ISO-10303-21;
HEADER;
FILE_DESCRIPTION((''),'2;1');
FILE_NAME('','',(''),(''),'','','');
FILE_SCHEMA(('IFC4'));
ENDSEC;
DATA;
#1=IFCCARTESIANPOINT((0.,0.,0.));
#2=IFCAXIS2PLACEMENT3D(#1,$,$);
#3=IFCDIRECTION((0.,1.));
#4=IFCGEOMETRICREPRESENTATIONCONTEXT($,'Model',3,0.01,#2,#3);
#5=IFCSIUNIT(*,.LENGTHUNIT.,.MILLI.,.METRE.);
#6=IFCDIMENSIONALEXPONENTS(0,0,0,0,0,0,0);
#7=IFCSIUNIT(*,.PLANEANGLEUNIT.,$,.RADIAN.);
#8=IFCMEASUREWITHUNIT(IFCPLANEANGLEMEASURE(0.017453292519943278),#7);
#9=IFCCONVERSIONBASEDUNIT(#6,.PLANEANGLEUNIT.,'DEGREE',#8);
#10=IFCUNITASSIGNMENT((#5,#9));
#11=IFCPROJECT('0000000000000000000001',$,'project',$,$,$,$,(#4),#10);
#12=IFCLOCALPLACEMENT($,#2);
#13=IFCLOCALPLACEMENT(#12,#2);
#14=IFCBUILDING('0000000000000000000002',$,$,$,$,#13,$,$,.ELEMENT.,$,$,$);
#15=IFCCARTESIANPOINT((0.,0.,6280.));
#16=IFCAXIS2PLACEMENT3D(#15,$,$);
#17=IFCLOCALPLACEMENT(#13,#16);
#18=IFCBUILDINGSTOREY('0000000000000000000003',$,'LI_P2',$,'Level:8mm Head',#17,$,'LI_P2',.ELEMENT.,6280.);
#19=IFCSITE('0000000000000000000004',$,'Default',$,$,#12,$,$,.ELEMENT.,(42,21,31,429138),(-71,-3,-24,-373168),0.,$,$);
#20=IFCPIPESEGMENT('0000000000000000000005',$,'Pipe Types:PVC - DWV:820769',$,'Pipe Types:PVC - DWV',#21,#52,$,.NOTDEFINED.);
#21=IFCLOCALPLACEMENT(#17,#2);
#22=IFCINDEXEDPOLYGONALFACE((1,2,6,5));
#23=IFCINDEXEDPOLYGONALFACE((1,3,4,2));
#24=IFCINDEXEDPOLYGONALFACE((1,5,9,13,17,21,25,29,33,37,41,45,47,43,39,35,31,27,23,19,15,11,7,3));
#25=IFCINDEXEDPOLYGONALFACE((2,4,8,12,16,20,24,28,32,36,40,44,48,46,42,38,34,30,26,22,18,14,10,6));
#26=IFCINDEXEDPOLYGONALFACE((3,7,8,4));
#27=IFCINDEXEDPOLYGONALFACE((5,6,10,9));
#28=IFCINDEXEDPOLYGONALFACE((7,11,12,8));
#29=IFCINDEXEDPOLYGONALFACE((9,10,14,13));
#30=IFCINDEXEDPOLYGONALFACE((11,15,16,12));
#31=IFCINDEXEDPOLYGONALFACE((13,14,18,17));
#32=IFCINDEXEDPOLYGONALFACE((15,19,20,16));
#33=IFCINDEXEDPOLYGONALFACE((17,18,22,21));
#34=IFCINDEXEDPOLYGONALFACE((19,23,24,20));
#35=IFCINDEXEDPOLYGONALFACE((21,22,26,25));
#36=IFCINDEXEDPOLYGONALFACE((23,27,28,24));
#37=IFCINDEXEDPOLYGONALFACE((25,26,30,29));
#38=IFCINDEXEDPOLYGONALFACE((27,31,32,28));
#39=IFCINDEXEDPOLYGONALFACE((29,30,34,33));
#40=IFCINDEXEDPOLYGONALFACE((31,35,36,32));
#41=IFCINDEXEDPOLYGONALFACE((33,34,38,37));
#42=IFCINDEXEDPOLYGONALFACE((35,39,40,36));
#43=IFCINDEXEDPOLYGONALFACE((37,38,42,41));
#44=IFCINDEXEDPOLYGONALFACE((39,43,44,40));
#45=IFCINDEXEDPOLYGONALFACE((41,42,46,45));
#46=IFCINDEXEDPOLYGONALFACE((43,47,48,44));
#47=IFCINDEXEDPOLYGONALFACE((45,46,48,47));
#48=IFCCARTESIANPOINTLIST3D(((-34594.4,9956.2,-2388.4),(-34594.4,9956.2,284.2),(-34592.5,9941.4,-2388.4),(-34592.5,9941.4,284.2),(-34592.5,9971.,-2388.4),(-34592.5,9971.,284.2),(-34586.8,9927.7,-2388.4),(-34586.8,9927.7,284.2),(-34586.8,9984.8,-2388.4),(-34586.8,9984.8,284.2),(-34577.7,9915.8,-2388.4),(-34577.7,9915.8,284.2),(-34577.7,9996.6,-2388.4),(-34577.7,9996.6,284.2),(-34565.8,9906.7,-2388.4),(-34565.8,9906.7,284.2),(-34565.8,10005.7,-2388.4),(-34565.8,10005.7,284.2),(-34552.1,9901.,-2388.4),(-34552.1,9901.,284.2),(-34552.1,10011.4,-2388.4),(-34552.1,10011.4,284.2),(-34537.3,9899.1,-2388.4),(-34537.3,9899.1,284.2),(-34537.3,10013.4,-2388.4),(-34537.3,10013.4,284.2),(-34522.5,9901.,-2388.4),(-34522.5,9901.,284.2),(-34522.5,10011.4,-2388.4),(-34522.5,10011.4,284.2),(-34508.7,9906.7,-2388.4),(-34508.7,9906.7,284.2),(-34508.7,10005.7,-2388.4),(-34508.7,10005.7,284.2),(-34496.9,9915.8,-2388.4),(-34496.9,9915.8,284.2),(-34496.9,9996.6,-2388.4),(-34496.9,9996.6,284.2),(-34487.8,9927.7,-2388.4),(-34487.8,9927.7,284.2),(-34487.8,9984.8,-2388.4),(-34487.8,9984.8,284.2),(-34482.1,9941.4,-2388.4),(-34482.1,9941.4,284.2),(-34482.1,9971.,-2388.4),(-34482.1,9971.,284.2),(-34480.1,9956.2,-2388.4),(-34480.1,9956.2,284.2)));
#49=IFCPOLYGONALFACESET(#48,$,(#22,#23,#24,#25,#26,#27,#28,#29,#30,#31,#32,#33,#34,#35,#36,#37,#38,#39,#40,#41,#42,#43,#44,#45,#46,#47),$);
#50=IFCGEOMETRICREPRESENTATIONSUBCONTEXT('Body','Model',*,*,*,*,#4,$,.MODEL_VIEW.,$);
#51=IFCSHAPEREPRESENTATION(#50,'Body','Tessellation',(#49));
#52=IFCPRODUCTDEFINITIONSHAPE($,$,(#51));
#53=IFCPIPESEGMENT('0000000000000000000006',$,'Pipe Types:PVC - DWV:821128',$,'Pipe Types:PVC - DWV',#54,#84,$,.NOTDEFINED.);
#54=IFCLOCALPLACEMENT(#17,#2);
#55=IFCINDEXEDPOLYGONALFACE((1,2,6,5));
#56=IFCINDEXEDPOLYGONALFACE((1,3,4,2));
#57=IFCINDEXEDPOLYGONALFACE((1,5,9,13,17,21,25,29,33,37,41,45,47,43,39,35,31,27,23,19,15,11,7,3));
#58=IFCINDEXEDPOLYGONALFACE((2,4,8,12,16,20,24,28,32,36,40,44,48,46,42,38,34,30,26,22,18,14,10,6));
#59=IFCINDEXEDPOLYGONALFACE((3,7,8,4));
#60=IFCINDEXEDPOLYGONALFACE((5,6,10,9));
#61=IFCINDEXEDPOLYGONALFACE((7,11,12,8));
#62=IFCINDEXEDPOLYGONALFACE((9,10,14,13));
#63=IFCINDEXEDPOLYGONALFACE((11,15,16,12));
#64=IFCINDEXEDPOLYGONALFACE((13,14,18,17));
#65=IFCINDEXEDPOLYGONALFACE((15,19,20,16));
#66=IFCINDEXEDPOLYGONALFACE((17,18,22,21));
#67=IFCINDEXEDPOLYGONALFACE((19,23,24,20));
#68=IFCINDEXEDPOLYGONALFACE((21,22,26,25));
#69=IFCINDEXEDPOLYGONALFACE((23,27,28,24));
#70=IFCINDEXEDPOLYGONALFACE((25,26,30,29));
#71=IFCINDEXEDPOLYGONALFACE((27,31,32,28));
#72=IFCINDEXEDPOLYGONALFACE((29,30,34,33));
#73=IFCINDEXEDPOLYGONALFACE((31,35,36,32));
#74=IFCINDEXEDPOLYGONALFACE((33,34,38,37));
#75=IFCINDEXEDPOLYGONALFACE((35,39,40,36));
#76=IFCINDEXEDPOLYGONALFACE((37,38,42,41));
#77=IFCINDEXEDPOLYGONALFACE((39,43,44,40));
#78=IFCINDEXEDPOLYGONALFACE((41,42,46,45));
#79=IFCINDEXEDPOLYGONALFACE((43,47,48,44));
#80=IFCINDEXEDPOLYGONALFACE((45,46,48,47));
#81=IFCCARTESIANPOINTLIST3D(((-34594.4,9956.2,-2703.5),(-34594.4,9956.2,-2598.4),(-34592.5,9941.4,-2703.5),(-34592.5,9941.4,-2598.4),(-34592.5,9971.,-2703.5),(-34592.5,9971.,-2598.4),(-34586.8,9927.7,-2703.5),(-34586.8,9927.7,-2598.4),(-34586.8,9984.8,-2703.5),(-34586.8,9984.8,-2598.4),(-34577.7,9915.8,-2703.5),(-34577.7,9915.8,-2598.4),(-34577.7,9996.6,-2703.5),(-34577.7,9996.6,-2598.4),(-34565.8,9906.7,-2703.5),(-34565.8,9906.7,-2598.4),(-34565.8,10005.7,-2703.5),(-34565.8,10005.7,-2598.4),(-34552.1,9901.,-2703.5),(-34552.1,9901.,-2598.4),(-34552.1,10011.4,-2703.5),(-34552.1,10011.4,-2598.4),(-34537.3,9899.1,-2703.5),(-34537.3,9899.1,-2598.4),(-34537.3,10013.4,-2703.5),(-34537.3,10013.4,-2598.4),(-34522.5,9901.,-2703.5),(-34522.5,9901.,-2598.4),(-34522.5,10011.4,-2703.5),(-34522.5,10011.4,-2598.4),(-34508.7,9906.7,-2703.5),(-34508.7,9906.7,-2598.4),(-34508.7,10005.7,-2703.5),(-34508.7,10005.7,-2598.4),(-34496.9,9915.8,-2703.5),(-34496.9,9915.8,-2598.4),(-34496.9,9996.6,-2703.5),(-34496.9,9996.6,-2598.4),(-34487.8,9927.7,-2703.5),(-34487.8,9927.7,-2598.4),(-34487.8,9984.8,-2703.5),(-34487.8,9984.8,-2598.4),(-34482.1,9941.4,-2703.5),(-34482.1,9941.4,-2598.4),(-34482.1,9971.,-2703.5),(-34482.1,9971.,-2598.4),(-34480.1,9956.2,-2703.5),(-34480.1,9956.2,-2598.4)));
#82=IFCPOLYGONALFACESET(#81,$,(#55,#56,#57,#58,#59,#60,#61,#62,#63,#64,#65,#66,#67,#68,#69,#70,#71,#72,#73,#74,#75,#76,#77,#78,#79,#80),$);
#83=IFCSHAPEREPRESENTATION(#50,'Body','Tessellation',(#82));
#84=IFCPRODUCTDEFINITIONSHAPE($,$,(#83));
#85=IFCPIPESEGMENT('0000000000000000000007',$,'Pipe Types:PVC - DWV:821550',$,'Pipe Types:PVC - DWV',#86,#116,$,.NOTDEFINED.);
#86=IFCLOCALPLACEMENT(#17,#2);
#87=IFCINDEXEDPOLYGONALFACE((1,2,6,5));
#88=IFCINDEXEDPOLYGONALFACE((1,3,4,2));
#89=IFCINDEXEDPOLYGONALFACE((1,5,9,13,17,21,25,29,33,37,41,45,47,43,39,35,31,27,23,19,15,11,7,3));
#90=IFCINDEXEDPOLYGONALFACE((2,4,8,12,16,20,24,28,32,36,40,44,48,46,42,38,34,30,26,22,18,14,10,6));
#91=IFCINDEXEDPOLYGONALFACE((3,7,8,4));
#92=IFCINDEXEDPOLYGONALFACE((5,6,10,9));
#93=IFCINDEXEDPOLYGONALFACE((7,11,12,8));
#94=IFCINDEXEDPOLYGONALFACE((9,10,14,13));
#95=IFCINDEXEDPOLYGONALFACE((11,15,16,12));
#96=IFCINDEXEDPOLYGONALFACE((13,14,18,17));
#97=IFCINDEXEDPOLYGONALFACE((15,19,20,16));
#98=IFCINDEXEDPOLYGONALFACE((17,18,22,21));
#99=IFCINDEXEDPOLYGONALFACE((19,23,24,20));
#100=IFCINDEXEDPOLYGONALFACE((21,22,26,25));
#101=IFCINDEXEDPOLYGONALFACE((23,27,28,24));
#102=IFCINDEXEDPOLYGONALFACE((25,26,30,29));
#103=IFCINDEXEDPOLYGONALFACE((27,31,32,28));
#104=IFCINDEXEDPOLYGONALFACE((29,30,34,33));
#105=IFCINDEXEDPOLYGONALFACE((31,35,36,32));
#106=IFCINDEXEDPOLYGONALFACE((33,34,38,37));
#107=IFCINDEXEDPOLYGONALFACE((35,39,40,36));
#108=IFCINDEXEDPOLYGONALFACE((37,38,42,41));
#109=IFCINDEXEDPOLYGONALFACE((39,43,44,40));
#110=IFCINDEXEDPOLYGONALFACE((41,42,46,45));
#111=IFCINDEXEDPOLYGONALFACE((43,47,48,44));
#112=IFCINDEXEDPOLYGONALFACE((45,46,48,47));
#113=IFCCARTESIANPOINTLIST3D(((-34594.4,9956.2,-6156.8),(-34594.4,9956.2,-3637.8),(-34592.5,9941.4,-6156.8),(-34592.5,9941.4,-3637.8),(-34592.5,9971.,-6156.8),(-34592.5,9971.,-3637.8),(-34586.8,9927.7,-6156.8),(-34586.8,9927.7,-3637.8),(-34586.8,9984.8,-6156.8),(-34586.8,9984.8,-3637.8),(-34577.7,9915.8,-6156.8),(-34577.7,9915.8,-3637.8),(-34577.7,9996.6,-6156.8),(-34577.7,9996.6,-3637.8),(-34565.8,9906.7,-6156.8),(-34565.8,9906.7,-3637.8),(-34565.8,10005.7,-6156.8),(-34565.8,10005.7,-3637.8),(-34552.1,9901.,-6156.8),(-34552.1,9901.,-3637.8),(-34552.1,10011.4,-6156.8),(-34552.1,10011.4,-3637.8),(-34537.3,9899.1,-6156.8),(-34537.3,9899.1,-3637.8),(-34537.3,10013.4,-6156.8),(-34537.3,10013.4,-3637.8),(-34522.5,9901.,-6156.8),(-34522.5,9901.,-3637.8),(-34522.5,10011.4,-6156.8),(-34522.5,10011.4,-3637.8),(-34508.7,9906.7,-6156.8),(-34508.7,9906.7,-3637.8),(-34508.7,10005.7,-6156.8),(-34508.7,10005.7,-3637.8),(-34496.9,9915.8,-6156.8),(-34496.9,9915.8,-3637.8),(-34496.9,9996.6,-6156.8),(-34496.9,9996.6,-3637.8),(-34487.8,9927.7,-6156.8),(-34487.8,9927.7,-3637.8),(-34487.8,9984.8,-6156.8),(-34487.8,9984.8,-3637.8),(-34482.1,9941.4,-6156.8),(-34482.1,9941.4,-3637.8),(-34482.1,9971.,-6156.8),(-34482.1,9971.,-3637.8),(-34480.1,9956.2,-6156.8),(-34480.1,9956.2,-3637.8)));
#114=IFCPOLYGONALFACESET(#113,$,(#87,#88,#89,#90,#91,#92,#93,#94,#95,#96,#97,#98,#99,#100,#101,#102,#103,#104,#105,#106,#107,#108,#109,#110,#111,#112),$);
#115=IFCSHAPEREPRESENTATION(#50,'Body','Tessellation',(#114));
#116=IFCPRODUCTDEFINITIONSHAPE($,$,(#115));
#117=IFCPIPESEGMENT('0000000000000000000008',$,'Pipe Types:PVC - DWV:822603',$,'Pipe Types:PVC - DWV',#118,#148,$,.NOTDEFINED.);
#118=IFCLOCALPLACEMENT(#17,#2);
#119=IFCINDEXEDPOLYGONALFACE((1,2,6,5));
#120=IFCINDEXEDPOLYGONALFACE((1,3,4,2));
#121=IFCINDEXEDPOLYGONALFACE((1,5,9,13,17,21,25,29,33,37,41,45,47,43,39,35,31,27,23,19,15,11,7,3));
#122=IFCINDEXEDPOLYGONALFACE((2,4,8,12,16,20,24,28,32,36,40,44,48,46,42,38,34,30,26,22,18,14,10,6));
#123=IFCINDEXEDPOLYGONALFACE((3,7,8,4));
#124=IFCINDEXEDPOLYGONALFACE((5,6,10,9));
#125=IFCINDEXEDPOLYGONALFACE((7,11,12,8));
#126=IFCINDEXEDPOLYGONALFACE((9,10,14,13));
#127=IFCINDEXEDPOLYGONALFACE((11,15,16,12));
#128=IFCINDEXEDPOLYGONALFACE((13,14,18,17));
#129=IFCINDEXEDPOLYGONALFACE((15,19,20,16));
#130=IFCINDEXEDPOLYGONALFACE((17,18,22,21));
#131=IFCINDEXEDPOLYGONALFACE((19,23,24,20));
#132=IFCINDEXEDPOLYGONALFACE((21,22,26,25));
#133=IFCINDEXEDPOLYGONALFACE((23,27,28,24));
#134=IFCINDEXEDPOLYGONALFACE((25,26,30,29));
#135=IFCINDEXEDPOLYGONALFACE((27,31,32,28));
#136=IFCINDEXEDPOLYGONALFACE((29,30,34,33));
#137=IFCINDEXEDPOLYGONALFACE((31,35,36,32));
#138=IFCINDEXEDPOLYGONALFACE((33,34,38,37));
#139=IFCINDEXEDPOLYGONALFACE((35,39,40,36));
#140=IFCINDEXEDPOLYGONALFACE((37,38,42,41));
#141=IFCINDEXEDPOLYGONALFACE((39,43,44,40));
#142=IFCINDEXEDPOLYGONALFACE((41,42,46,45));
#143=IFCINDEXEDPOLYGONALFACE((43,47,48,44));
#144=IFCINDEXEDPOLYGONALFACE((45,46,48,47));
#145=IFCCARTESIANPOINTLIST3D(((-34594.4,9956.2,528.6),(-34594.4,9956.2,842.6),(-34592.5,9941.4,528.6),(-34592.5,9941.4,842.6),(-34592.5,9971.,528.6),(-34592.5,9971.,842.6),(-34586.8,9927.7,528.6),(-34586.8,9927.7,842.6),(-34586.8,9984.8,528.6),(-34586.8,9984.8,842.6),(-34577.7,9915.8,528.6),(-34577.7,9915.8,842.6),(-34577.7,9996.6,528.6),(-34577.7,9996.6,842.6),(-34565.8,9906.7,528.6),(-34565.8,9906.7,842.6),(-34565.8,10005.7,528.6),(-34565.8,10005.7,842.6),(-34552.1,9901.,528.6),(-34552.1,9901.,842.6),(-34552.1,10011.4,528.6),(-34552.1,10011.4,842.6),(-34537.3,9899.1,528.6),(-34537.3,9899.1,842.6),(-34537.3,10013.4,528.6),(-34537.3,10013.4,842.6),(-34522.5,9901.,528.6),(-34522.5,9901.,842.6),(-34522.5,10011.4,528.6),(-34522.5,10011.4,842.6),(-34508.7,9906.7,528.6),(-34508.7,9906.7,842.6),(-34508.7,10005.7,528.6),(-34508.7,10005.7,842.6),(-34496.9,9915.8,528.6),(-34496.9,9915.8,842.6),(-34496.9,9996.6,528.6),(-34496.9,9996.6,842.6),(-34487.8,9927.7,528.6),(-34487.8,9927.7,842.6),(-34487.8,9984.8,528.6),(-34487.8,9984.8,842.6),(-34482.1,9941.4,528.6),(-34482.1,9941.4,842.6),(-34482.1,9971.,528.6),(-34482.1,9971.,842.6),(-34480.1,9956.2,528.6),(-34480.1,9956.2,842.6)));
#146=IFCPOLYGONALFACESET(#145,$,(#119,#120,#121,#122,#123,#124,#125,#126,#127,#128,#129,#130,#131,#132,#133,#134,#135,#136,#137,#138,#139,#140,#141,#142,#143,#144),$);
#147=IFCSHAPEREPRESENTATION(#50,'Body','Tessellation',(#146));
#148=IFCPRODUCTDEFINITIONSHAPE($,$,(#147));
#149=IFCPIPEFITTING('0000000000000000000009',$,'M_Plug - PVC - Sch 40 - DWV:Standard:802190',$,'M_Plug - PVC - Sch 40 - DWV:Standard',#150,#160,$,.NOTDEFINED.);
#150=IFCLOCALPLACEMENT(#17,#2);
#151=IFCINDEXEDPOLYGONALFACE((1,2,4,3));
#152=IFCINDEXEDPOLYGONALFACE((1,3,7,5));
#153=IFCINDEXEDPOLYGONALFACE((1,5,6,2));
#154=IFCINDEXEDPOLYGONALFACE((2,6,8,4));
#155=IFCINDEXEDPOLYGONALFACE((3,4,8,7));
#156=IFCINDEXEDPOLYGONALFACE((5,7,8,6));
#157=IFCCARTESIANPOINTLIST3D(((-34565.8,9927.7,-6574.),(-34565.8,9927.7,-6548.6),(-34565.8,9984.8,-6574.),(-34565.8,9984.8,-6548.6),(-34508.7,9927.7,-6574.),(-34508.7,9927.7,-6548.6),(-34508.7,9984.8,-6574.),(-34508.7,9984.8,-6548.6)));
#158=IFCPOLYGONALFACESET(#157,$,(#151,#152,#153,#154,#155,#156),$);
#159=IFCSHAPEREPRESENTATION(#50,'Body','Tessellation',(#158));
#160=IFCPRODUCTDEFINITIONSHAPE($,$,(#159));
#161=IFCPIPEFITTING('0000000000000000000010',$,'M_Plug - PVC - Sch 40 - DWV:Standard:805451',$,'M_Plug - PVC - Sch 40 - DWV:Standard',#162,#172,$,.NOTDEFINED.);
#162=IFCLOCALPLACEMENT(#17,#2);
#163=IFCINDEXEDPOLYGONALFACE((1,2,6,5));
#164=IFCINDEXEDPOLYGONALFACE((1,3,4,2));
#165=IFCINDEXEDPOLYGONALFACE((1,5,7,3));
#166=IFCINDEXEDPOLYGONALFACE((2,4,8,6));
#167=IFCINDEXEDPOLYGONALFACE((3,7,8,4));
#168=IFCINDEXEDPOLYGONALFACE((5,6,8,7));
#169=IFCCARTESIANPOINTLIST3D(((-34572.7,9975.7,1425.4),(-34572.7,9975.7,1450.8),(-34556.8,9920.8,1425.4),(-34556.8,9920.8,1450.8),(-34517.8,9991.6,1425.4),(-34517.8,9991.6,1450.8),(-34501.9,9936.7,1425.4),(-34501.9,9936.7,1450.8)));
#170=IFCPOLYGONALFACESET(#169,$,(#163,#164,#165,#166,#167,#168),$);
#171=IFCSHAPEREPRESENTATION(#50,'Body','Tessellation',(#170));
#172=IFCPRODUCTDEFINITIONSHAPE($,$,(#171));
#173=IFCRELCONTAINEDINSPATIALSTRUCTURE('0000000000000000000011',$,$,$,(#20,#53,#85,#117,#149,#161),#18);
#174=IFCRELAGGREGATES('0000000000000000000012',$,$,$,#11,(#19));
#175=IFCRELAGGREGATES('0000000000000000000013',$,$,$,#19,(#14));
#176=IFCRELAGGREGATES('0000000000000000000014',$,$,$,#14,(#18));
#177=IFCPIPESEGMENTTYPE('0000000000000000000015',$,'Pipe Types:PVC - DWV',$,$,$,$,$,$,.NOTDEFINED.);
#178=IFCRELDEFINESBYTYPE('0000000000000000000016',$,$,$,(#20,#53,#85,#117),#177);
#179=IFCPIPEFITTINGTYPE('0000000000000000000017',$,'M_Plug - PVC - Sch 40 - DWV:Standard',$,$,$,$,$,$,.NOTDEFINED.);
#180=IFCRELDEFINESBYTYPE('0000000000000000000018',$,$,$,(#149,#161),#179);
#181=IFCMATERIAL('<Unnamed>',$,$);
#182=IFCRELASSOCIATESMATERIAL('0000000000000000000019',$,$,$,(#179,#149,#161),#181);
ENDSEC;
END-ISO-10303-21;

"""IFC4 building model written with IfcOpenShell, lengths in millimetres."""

from ifc_helpers import new_model, entity, si_unit, converted_unit, direction, frame, origin, place, context, subcontext, project, spatial, arc, indexed_curve, outline, extrude, source, transform, mapped, material, type_object, type_shapes, element, save


model = new_model("IFC4")

# Units and contexts
model_context = context("Model", 3, precision=0.01, world=origin(), true_north=direction((0.0, 1.0)))
body_context = subcontext(model_context, "Body", "Model", "MODEL_VIEW")
ifc_project = project(units=[si_unit("LENGTHUNIT", "METRE", prefix="MILLI"), converted_unit("PLANEANGLEUNIT", "DEGREE", entity("IfcPlaneAngleMeasure", 0.017453292519943278), si_unit("PLANEANGLEUNIT", "RADIAN"), dimensions=[0, 0, 0, 0, 0, 0, 0])], contexts=[model_context])

# Site, building, storey
site_placement = place(None, origin())
site = spatial("IfcSite", under=ifc_project, at=site_placement, Name="Default", CompositionType="ELEMENT", RefLatitude=(42, 21, 31, 429138), RefLongitude=(-71, -3, -24, -373168), RefElevation=0.0)
building_placement = place(site_placement, origin())
building = spatial("IfcBuilding", under=site, at=building_placement, CompositionType="ELEMENT")
storey_placement = place(building_placement, frame((0.0, 0.0, 6280.0)))
storey = spatial("IfcBuildingStorey", under=building, at=storey_placement, Name="LI_P2", ObjectType="Level:8mm Head", LongName="LI_P2", CompositionType="ELEMENT", Elevation=6280.0)

# Pipe segments
pipe_segment_type = type_object("IfcPipeSegmentType", Name="Pipe Types:PVC - DWV", PredefinedType="NOTDEFINED")
pipe_segment_1_placement = place(storey_placement, origin())
element("IfcPipeSegment", 1, at=pipe_segment_1_placement, inside=storey, type_object=pipe_segment_type, Name="Pipe Types:PVC - DWV:820769", ObjectType="Pipe Types:PVC - DWV", PredefinedType="NOTDEFINED", context=body_context, shape_type="SweptSolid", body=[
    extrude(outline(indexed_curve([(57.2, 0.0), (40.4, 40.4), (0.0, 57.2), (-40.4, 40.4), (-57.2, 0.0), (-40.4, -40.4), (0.0, -57.2), (40.4, -40.4)], segments=[arc(1, 2, 3), arc(3, 4, 5), arc(5, 6, 7), arc(7, 8, 1)], self_intersect=False)), frame((-34537.3, 9956.2, -2388.4), z_axis=(0.0, 0.0, 1.0), x_axis=(-1.0, 0.0, 0.0)), (0.0, 0.0, 1.0), 2672.6),
])
pipe_segment_2_placement = place(storey_placement, origin())
element("IfcPipeSegment", 2, at=pipe_segment_2_placement, inside=storey, type_object=pipe_segment_type, Name="Pipe Types:PVC - DWV:821128", ObjectType="Pipe Types:PVC - DWV", PredefinedType="NOTDEFINED", context=body_context, shape_type="SweptSolid", body=[
    extrude(outline(indexed_curve([(57.2, 0.0), (40.4, 40.4), (0.0, 57.2), (-40.4, 40.4), (-57.2, 0.0), (-40.4, -40.4), (0.0, -57.2), (40.4, -40.4)], segments=[arc(1, 2, 3), arc(3, 4, 5), arc(5, 6, 7), arc(7, 8, 1)], self_intersect=False)), frame((-34537.3, 9956.2, -2703.5), z_axis=(0.0, 0.0, 1.0), x_axis=(-1.0, 0.0, 0.0)), (0.0, 0.0, 1.0), 105.0),
])
pipe_segment_3_placement = place(storey_placement, origin())
element("IfcPipeSegment", 3, at=pipe_segment_3_placement, inside=storey, type_object=pipe_segment_type, Name="Pipe Types:PVC - DWV:821550", ObjectType="Pipe Types:PVC - DWV", PredefinedType="NOTDEFINED", context=body_context, shape_type="SweptSolid", body=[
    extrude(outline(indexed_curve([(57.2, 0.0), (40.4, 40.4), (0.0, 57.2), (-40.4, 40.4), (-57.2, 0.0), (-40.4, -40.4), (0.0, -57.2), (40.4, -40.4)], segments=[arc(1, 2, 3), arc(3, 4, 5), arc(5, 6, 7), arc(7, 8, 1)], self_intersect=False)), frame((-34537.3, 9956.2, -6156.8), z_axis=(0.0, 0.0, 1.0), x_axis=(-1.0, 0.0, 0.0)), (0.0, 0.0, 1.0), 2518.9),
])
pipe_segment_4_placement = place(storey_placement, origin())
element("IfcPipeSegment", 4, at=pipe_segment_4_placement, inside=storey, type_object=pipe_segment_type, Name="Pipe Types:PVC - DWV:822603", ObjectType="Pipe Types:PVC - DWV", PredefinedType="NOTDEFINED", context=body_context, shape_type="SweptSolid", body=[
    extrude(outline(indexed_curve([(57.2, 0.0), (40.4, 40.4), (0.0, 57.2), (-40.4, 40.4), (-57.2, 0.0), (-40.4, -40.4), (0.0, -57.2), (40.4, -40.4)], segments=[arc(1, 2, 3), arc(3, 4, 5), arc(5, 6, 7), arc(7, 8, 1)], self_intersect=False)), frame((-34537.3, 9956.2, 528.6), z_axis=(0.0, 0.0, 1.0), x_axis=(-1.0, 0.0, 0.0)), (0.0, 0.0, 1.0), 314.0),
])

# Pipe fittings
ifc_material = material(Name="<Unnamed>")
pipe_fitting_type = type_object("IfcPipeFittingType", Name="M_Plug - PVC - Sch 40 - DWV:Standard", PredefinedType="NOTDEFINED", material=ifc_material)
shared_shape = source(origin(), body_context, "Body", "SweptSolid", [
    extrude(outline(indexed_curve([(-12.7, -28.6), (12.7, -28.6), (12.7, 28.6), (-12.7, 28.6), (-12.7, -28.6)], self_intersect=False)), frame((12.7, 0.0, -28.6), z_axis=(0.0, 0.0, 1.0), x_axis=(-1.0, 0.0, 0.0)), (0.0, 0.0, 1.0), 57.2),
])
type_shapes(pipe_fitting_type, [shared_shape])
for number, where, z_axis, x_axis, name in (
    (5, (-34537.3, 9956.2, -6548.6), (1.0, 0.0, 0.0), (0.0, 0.0, -1.0), "M_Plug - PVC - Sch 40 - DWV:Standard:802190"),
    (6, (-34537.3, 9956.2, 1425.4), (0.277949, -0.960596, 0.0), (0.0, 0.0, 1.0), "M_Plug - PVC - Sch 40 - DWV:Standard:805451"),
):
    element("IfcPipeFitting", number, at=place(storey_placement, frame(where, z_axis=z_axis, x_axis=x_axis)), inside=storey, type_object=pipe_fitting_type, material=ifc_material, Name=name, ObjectType="M_Plug - PVC - Sch 40 - DWV:Standard", PredefinedType="NOTDEFINED", context=body_context, shape_type="MappedRepresentation", body=[
        mapped(shared_shape, transform((0.0, 0.0, 0.0), scale=1.0)),
    ])

save(model, "model.ifc")
